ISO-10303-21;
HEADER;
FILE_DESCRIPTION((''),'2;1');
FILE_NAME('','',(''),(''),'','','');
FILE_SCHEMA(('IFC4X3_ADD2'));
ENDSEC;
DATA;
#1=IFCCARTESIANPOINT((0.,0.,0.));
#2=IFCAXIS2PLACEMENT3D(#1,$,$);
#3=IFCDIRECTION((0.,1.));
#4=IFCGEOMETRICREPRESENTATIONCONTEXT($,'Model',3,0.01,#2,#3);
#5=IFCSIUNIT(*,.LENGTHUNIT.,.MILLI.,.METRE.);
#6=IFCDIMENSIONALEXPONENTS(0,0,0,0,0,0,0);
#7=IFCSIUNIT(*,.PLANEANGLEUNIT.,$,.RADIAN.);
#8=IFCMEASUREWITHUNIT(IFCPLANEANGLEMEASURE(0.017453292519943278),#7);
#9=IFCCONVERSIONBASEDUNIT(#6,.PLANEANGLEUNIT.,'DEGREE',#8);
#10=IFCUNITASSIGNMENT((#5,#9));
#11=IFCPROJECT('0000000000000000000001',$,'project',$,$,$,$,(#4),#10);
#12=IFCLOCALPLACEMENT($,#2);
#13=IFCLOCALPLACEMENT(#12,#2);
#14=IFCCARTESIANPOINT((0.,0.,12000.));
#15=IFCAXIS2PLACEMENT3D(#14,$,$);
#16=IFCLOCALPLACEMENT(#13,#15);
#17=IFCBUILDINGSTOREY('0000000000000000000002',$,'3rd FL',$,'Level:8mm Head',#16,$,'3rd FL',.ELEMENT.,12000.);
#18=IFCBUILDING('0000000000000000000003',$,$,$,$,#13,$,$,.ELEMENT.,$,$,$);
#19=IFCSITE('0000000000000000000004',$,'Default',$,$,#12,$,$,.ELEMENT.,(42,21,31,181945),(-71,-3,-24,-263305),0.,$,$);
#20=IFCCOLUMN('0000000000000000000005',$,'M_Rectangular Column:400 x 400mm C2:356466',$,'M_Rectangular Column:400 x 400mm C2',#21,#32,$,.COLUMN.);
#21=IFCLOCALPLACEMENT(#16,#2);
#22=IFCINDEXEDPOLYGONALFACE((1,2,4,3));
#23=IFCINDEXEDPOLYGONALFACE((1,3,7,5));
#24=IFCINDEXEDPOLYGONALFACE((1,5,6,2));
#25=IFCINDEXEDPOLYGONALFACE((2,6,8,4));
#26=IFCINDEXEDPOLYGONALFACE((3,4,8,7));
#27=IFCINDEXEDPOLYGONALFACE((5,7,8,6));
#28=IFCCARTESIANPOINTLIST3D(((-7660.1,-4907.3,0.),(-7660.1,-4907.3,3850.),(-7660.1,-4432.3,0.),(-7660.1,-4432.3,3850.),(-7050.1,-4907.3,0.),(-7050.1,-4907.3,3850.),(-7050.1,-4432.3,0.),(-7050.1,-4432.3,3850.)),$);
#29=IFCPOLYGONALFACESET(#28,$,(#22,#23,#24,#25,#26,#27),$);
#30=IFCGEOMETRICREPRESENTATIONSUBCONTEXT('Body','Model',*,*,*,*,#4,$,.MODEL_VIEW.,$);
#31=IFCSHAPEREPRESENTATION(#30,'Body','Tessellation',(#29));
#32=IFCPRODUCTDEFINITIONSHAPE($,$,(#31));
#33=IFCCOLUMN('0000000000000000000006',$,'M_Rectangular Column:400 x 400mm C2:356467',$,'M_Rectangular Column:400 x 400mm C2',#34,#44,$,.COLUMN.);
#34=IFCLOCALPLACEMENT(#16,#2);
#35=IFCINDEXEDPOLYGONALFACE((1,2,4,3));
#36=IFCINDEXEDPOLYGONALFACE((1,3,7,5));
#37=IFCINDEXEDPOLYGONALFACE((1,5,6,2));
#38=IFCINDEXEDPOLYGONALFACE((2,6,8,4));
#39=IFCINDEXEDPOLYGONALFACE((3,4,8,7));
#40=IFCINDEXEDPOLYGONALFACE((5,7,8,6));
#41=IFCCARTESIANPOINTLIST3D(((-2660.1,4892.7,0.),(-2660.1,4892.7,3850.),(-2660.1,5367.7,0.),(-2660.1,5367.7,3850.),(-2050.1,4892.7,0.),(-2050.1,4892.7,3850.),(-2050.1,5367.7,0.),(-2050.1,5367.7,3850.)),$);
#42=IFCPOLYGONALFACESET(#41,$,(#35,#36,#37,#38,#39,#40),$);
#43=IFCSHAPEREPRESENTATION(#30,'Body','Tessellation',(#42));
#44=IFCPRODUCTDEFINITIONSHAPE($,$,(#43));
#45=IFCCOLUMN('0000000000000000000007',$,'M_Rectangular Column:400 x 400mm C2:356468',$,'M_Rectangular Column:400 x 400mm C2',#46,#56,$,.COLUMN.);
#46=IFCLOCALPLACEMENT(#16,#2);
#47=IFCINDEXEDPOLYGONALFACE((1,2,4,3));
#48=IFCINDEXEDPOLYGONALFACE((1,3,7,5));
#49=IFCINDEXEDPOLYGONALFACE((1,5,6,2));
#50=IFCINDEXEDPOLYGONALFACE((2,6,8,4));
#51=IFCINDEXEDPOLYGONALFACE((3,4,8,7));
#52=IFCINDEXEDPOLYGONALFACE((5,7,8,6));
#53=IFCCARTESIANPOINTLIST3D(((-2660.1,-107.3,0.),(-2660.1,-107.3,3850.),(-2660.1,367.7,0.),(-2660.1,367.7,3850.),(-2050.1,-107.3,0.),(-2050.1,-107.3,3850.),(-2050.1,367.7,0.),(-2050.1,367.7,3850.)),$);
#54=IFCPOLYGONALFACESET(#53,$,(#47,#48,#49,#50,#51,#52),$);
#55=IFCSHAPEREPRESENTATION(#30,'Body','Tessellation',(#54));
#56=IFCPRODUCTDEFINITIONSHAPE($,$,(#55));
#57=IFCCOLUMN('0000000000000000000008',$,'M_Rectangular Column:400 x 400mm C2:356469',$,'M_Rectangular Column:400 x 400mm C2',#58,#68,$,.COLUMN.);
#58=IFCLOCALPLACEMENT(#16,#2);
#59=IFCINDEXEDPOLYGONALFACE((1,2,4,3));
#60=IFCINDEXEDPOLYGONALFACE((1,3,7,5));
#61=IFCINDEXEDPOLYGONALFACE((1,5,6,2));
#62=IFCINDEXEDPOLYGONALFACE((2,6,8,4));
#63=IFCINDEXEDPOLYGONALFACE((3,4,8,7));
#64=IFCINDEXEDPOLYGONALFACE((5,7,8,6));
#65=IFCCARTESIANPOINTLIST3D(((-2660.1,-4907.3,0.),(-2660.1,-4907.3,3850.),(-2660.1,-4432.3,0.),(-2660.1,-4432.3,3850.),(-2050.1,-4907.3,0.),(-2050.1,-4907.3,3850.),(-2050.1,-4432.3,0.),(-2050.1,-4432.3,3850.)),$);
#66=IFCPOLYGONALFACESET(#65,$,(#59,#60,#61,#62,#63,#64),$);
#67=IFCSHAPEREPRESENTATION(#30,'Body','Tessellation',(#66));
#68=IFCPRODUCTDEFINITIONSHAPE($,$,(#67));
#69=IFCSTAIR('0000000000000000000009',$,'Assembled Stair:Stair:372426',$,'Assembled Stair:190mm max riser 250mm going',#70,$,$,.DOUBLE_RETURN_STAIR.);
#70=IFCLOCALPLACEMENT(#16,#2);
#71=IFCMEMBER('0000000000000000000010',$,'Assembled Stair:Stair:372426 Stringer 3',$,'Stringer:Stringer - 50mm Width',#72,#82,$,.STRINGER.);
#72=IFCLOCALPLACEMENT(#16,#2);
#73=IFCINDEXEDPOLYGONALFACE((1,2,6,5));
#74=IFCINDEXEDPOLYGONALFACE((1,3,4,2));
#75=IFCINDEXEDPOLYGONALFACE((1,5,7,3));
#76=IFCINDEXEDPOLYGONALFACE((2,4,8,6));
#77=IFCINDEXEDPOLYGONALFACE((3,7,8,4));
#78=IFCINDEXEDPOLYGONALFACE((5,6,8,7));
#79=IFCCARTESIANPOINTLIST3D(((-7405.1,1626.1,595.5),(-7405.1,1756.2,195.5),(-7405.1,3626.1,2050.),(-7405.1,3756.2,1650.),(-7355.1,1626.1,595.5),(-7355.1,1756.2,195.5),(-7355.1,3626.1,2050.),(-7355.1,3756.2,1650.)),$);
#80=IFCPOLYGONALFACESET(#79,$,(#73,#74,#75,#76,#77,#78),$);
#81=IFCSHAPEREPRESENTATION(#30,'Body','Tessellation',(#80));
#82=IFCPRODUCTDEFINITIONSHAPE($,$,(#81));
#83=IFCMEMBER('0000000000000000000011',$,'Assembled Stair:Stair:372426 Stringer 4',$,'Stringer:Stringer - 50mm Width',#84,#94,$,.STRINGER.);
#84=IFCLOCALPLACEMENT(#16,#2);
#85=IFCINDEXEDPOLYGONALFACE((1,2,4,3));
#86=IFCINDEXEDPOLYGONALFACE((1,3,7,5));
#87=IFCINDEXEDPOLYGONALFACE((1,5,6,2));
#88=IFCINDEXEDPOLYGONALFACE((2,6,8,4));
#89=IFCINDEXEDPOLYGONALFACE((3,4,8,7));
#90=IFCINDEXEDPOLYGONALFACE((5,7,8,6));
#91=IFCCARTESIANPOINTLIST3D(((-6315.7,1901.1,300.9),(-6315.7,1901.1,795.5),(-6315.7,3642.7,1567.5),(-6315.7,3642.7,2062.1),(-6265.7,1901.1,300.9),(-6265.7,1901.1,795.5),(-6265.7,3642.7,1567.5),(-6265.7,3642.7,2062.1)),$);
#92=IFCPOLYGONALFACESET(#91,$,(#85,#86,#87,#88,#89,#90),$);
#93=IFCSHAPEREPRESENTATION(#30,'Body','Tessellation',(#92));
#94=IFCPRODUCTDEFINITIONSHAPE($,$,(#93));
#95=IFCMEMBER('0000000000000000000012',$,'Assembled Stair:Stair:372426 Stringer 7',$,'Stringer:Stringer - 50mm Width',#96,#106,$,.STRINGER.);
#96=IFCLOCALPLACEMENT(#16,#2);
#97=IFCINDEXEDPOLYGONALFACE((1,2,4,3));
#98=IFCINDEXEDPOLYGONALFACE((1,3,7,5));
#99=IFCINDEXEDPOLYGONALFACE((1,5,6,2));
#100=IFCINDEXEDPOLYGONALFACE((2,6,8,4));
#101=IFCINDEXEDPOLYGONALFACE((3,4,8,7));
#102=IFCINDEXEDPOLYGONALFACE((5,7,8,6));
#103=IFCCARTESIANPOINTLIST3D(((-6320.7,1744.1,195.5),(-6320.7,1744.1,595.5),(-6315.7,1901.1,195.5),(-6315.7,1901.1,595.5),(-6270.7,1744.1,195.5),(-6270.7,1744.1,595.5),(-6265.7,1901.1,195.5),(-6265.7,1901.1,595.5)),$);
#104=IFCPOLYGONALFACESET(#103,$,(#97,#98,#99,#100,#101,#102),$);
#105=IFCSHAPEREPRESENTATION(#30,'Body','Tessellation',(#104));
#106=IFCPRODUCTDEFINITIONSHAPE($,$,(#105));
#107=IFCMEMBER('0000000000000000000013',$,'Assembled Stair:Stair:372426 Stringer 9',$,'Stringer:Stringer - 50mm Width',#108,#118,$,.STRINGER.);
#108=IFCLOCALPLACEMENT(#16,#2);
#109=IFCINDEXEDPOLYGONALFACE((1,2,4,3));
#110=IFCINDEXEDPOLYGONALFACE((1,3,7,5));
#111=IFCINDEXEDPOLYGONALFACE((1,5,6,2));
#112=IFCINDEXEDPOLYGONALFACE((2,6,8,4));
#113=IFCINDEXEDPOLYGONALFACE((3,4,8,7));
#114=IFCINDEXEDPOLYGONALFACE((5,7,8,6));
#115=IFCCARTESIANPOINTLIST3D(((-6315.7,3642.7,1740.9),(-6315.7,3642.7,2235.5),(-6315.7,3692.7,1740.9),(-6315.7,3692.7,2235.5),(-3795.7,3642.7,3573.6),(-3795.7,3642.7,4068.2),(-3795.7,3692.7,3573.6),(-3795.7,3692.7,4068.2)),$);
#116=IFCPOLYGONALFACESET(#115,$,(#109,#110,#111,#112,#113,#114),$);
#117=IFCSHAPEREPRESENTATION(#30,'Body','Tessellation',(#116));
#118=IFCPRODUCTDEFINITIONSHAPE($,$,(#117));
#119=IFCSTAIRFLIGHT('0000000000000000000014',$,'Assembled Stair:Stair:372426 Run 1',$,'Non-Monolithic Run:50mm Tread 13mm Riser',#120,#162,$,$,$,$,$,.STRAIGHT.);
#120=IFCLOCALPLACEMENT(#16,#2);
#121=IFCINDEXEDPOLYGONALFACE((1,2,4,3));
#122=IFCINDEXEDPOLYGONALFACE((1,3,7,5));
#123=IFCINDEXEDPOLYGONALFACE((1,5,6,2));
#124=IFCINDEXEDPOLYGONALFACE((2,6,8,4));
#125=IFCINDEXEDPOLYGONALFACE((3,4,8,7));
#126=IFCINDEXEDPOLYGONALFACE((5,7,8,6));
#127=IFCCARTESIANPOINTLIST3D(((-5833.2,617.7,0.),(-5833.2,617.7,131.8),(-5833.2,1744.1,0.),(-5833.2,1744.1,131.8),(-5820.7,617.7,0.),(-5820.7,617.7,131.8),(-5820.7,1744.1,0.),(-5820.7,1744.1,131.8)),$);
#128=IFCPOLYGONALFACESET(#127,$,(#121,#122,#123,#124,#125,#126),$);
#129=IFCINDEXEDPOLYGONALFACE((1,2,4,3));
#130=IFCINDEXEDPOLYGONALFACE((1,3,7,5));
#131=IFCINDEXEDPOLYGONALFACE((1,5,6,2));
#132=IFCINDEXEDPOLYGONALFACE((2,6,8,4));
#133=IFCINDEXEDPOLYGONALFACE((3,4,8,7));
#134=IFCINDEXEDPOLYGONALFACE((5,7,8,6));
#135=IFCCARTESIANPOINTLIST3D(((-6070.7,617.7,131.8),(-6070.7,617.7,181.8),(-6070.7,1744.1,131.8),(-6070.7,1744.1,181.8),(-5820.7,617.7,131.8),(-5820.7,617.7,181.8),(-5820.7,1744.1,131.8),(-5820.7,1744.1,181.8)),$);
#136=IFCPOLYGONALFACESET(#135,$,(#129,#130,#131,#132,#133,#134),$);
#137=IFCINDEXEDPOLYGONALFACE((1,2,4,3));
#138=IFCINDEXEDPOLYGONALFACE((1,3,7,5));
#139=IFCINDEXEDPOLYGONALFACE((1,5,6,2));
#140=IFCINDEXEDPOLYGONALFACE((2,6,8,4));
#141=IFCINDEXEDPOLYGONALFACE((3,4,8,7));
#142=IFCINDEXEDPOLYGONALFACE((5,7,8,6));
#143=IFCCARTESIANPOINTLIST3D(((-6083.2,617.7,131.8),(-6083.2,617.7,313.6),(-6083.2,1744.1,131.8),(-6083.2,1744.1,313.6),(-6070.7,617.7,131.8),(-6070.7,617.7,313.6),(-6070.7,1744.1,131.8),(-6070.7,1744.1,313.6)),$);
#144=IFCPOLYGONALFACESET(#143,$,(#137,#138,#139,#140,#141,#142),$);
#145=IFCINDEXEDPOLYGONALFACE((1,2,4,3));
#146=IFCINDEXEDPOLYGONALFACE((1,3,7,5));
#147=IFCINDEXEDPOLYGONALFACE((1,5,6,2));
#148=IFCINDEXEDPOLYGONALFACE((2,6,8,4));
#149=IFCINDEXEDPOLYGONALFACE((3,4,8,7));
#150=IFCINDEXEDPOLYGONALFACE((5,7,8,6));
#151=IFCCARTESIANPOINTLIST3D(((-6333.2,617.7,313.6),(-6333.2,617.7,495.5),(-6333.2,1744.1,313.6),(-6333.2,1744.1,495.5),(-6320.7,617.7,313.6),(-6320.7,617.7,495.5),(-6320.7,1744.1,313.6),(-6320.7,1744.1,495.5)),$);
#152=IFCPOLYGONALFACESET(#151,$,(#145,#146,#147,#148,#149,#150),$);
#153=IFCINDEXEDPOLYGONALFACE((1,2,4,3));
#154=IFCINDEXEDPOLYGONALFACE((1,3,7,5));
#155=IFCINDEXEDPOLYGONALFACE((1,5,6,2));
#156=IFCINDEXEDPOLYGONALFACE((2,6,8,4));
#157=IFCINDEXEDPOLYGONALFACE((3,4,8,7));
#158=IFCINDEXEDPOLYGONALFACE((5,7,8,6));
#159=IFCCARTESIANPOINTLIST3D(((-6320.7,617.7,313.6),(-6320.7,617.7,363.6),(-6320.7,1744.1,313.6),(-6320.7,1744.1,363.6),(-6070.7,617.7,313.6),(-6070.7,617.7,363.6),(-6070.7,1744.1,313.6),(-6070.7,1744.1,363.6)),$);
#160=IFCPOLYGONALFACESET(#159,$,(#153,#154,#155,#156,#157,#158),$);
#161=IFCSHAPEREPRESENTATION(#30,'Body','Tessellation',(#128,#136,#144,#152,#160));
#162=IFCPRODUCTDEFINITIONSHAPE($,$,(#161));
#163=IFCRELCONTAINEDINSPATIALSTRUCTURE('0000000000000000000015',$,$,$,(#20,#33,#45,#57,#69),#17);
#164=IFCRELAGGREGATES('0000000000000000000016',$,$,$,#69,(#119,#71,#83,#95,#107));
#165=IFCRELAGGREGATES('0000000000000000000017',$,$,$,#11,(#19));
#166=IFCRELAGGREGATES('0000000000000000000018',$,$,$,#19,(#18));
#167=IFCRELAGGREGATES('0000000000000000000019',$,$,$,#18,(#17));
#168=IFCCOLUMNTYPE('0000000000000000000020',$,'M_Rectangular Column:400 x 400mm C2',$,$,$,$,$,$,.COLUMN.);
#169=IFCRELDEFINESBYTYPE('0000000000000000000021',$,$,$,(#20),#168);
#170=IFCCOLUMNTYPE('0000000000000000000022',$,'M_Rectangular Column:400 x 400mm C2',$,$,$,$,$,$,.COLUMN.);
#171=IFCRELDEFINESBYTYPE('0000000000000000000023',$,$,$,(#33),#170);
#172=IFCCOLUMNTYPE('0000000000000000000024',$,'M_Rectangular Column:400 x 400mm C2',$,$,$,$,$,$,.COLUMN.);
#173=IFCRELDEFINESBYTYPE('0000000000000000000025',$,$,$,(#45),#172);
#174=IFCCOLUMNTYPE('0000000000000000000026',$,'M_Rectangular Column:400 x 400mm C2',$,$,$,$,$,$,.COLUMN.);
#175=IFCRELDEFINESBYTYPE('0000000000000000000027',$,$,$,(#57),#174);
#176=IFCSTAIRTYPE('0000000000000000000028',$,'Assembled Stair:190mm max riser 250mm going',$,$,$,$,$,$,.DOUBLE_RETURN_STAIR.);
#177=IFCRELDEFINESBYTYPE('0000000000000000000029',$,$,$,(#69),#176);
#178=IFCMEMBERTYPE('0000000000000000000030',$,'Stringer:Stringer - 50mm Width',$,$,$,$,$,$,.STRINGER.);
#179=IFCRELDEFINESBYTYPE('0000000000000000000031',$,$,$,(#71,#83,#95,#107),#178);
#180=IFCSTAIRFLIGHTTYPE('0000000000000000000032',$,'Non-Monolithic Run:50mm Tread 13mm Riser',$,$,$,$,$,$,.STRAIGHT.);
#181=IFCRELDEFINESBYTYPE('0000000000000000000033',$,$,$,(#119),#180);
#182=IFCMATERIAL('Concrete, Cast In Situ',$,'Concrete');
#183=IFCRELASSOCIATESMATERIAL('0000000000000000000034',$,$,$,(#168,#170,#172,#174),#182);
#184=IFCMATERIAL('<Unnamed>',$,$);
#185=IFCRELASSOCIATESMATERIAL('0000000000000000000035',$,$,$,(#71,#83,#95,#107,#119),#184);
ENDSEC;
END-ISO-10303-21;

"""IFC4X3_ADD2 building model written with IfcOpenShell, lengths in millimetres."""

from ifc_helpers import new_model, entity, si_unit, converted_unit, direction, frame, frame_2d, origin, origin_2d_with_axis, place, context, subcontext, project, spatial, polyline, rectangle, outline, extrude, source, transform, mapped, material, material_profile, profile_set, type_object, type_shapes, element, aggregate, save


model = new_model("IFC4X3_ADD2")

# Units and contexts
model_context = context("Model", 3, precision=0.01, world=origin(), true_north=direction((0.0, 1.0)))
body_context = subcontext(model_context, "Body", "Model", "MODEL_VIEW")
ifc_project = project(units=[si_unit("LENGTHUNIT", "METRE", prefix="MILLI"), converted_unit("PLANEANGLEUNIT", "DEGREE", entity("IfcPlaneAngleMeasure", 0.017453292519943278), si_unit("PLANEANGLEUNIT", "RADIAN"), dimensions=[0, 0, 0, 0, 0, 0, 0])], contexts=[model_context])

# Site, building, storey
site_placement = place(None, origin())
site = spatial("IfcSite", under=ifc_project, at=site_placement, Name="Default", CompositionType="ELEMENT", RefLatitude=(42, 21, 31, 181945), RefLongitude=(-71, -3, -24, -263305), RefElevation=0.0)
building_placement = place(site_placement, origin())
building = spatial("IfcBuilding", under=site, at=building_placement, CompositionType="ELEMENT")
storey_placement = place(building_placement, frame((0.0, 0.0, 12000.0)))
storey = spatial("IfcBuildingStorey", under=building, at=storey_placement, Name="3rd FL", ObjectType="Level:8mm Head", LongName="3rd FL", CompositionType="ELEMENT", Elevation=12000.0)

# Columns
ifc_material_1 = material(Name="Concrete, Cast In Situ", Category="Concrete")
ifc_material_profile_1 = material_profile(ifc_material_1, rectangle(XDim=610.0, YDim=475.0, at=origin_2d_with_axis()), Name="400 x 400mm C2")
ifc_profile_set_1 = profile_set([ifc_material_profile_1], Name="400 x 400mm C2")
column_type_1 = type_object("IfcColumnType", Name="M_Rectangular Column:400 x 400mm C2", PredefinedType="COLUMN", material=ifc_profile_set_1)
shared_shape_1 = source(origin(), body_context, "Body", "SweptSolid", [
    extrude(rectangle(XDim=610.0, YDim=475.0, at=frame_2d((0.0, 0.0), x_axis=(1.0, 0.0))), frame((-7355.1, -4669.8, 12000.0), z_axis=(0.0, 0.0, 1.0), x_axis=(-1.0, 0.0, 0.0)), (0.0, 0.0, 1.0), 3850.0),
])
type_shapes(column_type_1, [shared_shape_1])
column_1_placement = place(storey_placement, frame((0.0, 0.0, -12000.0)))
element("IfcColumn", 1, at=column_1_placement, inside=storey, type_object=column_type_1, Name="M_Rectangular Column:400 x 400mm C2:356466", ObjectType="M_Rectangular Column:400 x 400mm C2", PredefinedType="COLUMN", context=body_context, shape_type="MappedRepresentation", body=[
    mapped(shared_shape_1, transform((0.0, 0.0, 0.0), scale=1.0)),
])
column_type_2 = type_object("IfcColumnType", Name="M_Rectangular Column:400 x 400mm C2", PredefinedType="COLUMN", material=ifc_profile_set_1)
shared_shape_2 = source(origin(), body_context, "Body", "SweptSolid", [
    extrude(rectangle(XDim=610.0, YDim=475.0, at=frame_2d((0.0, 0.0), x_axis=(1.0, 0.0))), frame((-2355.1, 5130.2, 12000.0), z_axis=(0.0, 0.0, 1.0), x_axis=(-1.0, 0.0, 0.0)), (0.0, 0.0, 1.0), 3850.0),
])
type_shapes(column_type_2, [shared_shape_2])
column_2_placement = place(storey_placement, frame((0.0, 0.0, -12000.0)))
element("IfcColumn", 2, at=column_2_placement, inside=storey, type_object=column_type_2, Name="M_Rectangular Column:400 x 400mm C2:356467", ObjectType="M_Rectangular Column:400 x 400mm C2", PredefinedType="COLUMN", context=body_context, shape_type="MappedRepresentation", body=[
    mapped(shared_shape_2, transform((0.0, 0.0, 0.0), scale=1.0)),
])
column_type_3 = type_object("IfcColumnType", Name="M_Rectangular Column:400 x 400mm C2", PredefinedType="COLUMN", material=ifc_profile_set_1)
shared_shape_3 = source(origin(), body_context, "Body", "SweptSolid", [
    extrude(rectangle(XDim=610.0, YDim=475.0, at=frame_2d((0.0, 0.0), x_axis=(1.0, 0.0))), frame((-2355.1, 130.2, 12000.0), z_axis=(0.0, 0.0, 1.0), x_axis=(-1.0, 0.0, 0.0)), (0.0, 0.0, 1.0), 3850.0),
])
type_shapes(column_type_3, [shared_shape_3])
column_3_placement = place(storey_placement, frame((0.0, 0.0, -12000.0)))
element("IfcColumn", 3, at=column_3_placement, inside=storey, type_object=column_type_3, Name="M_Rectangular Column:400 x 400mm C2:356468", ObjectType="M_Rectangular Column:400 x 400mm C2", PredefinedType="COLUMN", context=body_context, shape_type="MappedRepresentation", body=[
    mapped(shared_shape_3, transform((0.0, 0.0, 0.0), scale=1.0)),
])
column_type_4 = type_object("IfcColumnType", Name="M_Rectangular Column:400 x 400mm C2", PredefinedType="COLUMN", material=ifc_profile_set_1)
shared_shape_4 = source(origin(), body_context, "Body", "SweptSolid", [
    extrude(rectangle(XDim=610.0, YDim=475.0, at=frame_2d((0.0, 0.0), x_axis=(1.0, 0.0))), frame((-2355.1, -4669.8, 12000.0), z_axis=(0.0, 0.0, 1.0), x_axis=(-1.0, 0.0, 0.0)), (0.0, 0.0, 1.0), 3850.0),
])
type_shapes(column_type_4, [shared_shape_4])
column_4_placement = place(storey_placement, frame((0.0, 0.0, -12000.0)))
element("IfcColumn", 4, at=column_4_placement, inside=storey, type_object=column_type_4, Name="M_Rectangular Column:400 x 400mm C2:356469", ObjectType="M_Rectangular Column:400 x 400mm C2", PredefinedType="COLUMN", context=body_context, shape_type="MappedRepresentation", body=[
    mapped(shared_shape_4, transform((0.0, 0.0, 0.0), scale=1.0)),
])

# Stair, members
stair_type = type_object("IfcStairType", Name="Assembled Stair:190mm max riser 250mm going", PredefinedType="DOUBLE_RETURN_STAIR")
stair_placement = place(storey_placement, origin())
stair = element("IfcStair", 5, at=stair_placement, inside=storey, type_object=stair_type, Name="Assembled Stair:Stair:372426", ObjectType="Assembled Stair:190mm max riser 250mm going", PredefinedType="DOUBLE_RETURN_STAIR")
ifc_material_2 = material(Name="<Unnamed>")
member_type = type_object("IfcMemberType", Name="Stringer:Stringer - 50mm Width", PredefinedType="STRINGER")
member_1_placement = place(stair_placement, frame((-7405.1, 1626.1, 195.5)))
member_1 = element("IfcMember", 6, at=member_1_placement, type_object=member_type, material=ifc_material_2, Name="Assembled Stair:Stair:372426 Stringer 3", ObjectType="Stringer:Stringer - 50mm Width", PredefinedType="STRINGER", context=body_context, shape_type="SweptSolid", body=[
    extrude(outline(polyline([(-1301.5, -200.0), (1171.5, -200.0), (1301.5, 200.0), (-1171.5, 200.0), (-1301.5, -200.0)])), frame((0.0, 1065.0, 927.3), z_axis=(1.0, 0.0, 0.0), x_axis=(0.0, 0.808736, 0.588172)), (0.0, 0.0, 1.0), 50.0),
])
member_2_placement = place(stair_placement, frame((-6315.7, 1901.1, 300.9)))
member_2 = element("IfcMember", 7, at=member_2_placement, type_object=member_type, material=ifc_material_2, Name="Assembled Stair:Stair:372426 Stringer 4", ObjectType="Stringer:Stringer - 50mm Width", PredefinedType="STRINGER", context=body_context, shape_type="SweptSolid", body=[
    extrude(outline(polyline([(-1222.2, -200.0), (931.3, -200.0), (1222.2, 200.0), (-931.3, 200.0), (-1222.2, -200.0)])), frame((0.0, 870.8, 880.6), z_axis=(1.0, 0.0, 0.0), x_axis=(0.0, 0.808736, 0.588172)), (0.0, 0.0, 1.0), 50.0),
])
member_3_placement = place(stair_placement, frame((-6320.7, 1744.1, 195.5)))
member_3 = element("IfcMember", 8, at=member_3_placement, type_object=member_type, material=ifc_material_2, Name="Assembled Stair:Stair:372426 Stringer 7", ObjectType="Stringer:Stringer - 50mm Width", PredefinedType="STRINGER", context=body_context, shape_type="SweptSolid", body=[
    extrude(outline(polyline([(-77.7, -25.0), (79.3, -25.0), (77.7, 25.0), (-79.3, 25.0), (-77.7, -25.0)])), frame((27.5, 78.5, 0.0), z_axis=(0.0, 0.0, 1.0), x_axis=(0.031792, 0.999495, 0.0)), (0.0, 0.0, 1.0), 400.0),
])
member_4_placement = place(stair_placement, frame((-6315.7, 3642.7, 1740.9)))
member_4 = element("IfcMember", 9, at=member_4_placement, type_object=member_type, material=ifc_material_2, Name="Assembled Stair:Stair:372426 Stringer 9", ObjectType="Stringer:Stringer - 50mm Width", PredefinedType="STRINGER", context=body_context, shape_type="SweptSolid", body=[
    extrude(outline(polyline([(-1412.6, -200.0), (1703.5, -200.0), (1412.6, 200.0), (-1703.5, 200.0), (-1412.6, -200.0)])), frame((1260.0, 0.0, 1163.7), z_axis=(0.0, 1.0, 0.0), x_axis=(0.808736, 0.0, 0.588172)), (0.0, 0.0, 1.0), 50.0),
])

# Stair flight
stair_flight_type = type_object("IfcStairFlightType", Name="Non-Monolithic Run:50mm Tread 13mm Riser", PredefinedType="STRAIGHT")
stair_flight_1_placement = place(stair_placement, frame((-6333.2, 617.7, 0.0)))
stair_flight_1 = element("IfcStairFlight", 10, at=stair_flight_1_placement, type_object=stair_flight_type, material=ifc_material_2, Name="Assembled Stair:Stair:372426 Run 1", ObjectType="Non-Monolithic Run:50mm Tread 13mm Riser", PredefinedType="STRAIGHT", context=body_context, shape_type="SweptSolid", body=[
    extrude(rectangle(XDim=1126.4, YDim=12.5, at=origin_2d_with_axis()), frame((506.3, 563.2, 0.0), z_axis=(0.0, 0.0, 1.0), x_axis=(0.0, -1.0, 0.0)), (0.0, 0.0, 1.0), 131.8),
    extrude(rectangle(XDim=250.0, YDim=1126.4, at=origin_2d_with_axis()), frame((387.5, 563.2, 131.8)), (0.0, 0.0, 1.0), 50.0),
    extrude(rectangle(XDim=1126.4, YDim=12.5, at=frame_2d((0.0, 0.0), x_axis=(1.0, 0.0))), frame((256.3, 563.2, 131.8), z_axis=(0.0, 0.0, 1.0), x_axis=(0.0, -1.0, 0.0)), (0.0, 0.0, 1.0), 181.8),
    extrude(rectangle(XDim=1126.4, YDim=12.5, at=frame_2d((0.0, 0.0), x_axis=(1.0, 0.0))), frame((6.3, 563.2, 313.6), z_axis=(0.0, 0.0, 1.0), x_axis=(0.0, -1.0, 0.0)), (0.0, 0.0, 1.0), 181.8),
    extrude(rectangle(XDim=250.0, YDim=1126.4, at=frame_2d((0.0, 0.0), x_axis=(1.0, 0.0))), frame((137.5, 563.2, 313.6)), (0.0, 0.0, 1.0), 50.0),
])
aggregate(stair, [stair_flight_1, member_1, member_2, member_3, member_4])

save(model, "model.ifc")
